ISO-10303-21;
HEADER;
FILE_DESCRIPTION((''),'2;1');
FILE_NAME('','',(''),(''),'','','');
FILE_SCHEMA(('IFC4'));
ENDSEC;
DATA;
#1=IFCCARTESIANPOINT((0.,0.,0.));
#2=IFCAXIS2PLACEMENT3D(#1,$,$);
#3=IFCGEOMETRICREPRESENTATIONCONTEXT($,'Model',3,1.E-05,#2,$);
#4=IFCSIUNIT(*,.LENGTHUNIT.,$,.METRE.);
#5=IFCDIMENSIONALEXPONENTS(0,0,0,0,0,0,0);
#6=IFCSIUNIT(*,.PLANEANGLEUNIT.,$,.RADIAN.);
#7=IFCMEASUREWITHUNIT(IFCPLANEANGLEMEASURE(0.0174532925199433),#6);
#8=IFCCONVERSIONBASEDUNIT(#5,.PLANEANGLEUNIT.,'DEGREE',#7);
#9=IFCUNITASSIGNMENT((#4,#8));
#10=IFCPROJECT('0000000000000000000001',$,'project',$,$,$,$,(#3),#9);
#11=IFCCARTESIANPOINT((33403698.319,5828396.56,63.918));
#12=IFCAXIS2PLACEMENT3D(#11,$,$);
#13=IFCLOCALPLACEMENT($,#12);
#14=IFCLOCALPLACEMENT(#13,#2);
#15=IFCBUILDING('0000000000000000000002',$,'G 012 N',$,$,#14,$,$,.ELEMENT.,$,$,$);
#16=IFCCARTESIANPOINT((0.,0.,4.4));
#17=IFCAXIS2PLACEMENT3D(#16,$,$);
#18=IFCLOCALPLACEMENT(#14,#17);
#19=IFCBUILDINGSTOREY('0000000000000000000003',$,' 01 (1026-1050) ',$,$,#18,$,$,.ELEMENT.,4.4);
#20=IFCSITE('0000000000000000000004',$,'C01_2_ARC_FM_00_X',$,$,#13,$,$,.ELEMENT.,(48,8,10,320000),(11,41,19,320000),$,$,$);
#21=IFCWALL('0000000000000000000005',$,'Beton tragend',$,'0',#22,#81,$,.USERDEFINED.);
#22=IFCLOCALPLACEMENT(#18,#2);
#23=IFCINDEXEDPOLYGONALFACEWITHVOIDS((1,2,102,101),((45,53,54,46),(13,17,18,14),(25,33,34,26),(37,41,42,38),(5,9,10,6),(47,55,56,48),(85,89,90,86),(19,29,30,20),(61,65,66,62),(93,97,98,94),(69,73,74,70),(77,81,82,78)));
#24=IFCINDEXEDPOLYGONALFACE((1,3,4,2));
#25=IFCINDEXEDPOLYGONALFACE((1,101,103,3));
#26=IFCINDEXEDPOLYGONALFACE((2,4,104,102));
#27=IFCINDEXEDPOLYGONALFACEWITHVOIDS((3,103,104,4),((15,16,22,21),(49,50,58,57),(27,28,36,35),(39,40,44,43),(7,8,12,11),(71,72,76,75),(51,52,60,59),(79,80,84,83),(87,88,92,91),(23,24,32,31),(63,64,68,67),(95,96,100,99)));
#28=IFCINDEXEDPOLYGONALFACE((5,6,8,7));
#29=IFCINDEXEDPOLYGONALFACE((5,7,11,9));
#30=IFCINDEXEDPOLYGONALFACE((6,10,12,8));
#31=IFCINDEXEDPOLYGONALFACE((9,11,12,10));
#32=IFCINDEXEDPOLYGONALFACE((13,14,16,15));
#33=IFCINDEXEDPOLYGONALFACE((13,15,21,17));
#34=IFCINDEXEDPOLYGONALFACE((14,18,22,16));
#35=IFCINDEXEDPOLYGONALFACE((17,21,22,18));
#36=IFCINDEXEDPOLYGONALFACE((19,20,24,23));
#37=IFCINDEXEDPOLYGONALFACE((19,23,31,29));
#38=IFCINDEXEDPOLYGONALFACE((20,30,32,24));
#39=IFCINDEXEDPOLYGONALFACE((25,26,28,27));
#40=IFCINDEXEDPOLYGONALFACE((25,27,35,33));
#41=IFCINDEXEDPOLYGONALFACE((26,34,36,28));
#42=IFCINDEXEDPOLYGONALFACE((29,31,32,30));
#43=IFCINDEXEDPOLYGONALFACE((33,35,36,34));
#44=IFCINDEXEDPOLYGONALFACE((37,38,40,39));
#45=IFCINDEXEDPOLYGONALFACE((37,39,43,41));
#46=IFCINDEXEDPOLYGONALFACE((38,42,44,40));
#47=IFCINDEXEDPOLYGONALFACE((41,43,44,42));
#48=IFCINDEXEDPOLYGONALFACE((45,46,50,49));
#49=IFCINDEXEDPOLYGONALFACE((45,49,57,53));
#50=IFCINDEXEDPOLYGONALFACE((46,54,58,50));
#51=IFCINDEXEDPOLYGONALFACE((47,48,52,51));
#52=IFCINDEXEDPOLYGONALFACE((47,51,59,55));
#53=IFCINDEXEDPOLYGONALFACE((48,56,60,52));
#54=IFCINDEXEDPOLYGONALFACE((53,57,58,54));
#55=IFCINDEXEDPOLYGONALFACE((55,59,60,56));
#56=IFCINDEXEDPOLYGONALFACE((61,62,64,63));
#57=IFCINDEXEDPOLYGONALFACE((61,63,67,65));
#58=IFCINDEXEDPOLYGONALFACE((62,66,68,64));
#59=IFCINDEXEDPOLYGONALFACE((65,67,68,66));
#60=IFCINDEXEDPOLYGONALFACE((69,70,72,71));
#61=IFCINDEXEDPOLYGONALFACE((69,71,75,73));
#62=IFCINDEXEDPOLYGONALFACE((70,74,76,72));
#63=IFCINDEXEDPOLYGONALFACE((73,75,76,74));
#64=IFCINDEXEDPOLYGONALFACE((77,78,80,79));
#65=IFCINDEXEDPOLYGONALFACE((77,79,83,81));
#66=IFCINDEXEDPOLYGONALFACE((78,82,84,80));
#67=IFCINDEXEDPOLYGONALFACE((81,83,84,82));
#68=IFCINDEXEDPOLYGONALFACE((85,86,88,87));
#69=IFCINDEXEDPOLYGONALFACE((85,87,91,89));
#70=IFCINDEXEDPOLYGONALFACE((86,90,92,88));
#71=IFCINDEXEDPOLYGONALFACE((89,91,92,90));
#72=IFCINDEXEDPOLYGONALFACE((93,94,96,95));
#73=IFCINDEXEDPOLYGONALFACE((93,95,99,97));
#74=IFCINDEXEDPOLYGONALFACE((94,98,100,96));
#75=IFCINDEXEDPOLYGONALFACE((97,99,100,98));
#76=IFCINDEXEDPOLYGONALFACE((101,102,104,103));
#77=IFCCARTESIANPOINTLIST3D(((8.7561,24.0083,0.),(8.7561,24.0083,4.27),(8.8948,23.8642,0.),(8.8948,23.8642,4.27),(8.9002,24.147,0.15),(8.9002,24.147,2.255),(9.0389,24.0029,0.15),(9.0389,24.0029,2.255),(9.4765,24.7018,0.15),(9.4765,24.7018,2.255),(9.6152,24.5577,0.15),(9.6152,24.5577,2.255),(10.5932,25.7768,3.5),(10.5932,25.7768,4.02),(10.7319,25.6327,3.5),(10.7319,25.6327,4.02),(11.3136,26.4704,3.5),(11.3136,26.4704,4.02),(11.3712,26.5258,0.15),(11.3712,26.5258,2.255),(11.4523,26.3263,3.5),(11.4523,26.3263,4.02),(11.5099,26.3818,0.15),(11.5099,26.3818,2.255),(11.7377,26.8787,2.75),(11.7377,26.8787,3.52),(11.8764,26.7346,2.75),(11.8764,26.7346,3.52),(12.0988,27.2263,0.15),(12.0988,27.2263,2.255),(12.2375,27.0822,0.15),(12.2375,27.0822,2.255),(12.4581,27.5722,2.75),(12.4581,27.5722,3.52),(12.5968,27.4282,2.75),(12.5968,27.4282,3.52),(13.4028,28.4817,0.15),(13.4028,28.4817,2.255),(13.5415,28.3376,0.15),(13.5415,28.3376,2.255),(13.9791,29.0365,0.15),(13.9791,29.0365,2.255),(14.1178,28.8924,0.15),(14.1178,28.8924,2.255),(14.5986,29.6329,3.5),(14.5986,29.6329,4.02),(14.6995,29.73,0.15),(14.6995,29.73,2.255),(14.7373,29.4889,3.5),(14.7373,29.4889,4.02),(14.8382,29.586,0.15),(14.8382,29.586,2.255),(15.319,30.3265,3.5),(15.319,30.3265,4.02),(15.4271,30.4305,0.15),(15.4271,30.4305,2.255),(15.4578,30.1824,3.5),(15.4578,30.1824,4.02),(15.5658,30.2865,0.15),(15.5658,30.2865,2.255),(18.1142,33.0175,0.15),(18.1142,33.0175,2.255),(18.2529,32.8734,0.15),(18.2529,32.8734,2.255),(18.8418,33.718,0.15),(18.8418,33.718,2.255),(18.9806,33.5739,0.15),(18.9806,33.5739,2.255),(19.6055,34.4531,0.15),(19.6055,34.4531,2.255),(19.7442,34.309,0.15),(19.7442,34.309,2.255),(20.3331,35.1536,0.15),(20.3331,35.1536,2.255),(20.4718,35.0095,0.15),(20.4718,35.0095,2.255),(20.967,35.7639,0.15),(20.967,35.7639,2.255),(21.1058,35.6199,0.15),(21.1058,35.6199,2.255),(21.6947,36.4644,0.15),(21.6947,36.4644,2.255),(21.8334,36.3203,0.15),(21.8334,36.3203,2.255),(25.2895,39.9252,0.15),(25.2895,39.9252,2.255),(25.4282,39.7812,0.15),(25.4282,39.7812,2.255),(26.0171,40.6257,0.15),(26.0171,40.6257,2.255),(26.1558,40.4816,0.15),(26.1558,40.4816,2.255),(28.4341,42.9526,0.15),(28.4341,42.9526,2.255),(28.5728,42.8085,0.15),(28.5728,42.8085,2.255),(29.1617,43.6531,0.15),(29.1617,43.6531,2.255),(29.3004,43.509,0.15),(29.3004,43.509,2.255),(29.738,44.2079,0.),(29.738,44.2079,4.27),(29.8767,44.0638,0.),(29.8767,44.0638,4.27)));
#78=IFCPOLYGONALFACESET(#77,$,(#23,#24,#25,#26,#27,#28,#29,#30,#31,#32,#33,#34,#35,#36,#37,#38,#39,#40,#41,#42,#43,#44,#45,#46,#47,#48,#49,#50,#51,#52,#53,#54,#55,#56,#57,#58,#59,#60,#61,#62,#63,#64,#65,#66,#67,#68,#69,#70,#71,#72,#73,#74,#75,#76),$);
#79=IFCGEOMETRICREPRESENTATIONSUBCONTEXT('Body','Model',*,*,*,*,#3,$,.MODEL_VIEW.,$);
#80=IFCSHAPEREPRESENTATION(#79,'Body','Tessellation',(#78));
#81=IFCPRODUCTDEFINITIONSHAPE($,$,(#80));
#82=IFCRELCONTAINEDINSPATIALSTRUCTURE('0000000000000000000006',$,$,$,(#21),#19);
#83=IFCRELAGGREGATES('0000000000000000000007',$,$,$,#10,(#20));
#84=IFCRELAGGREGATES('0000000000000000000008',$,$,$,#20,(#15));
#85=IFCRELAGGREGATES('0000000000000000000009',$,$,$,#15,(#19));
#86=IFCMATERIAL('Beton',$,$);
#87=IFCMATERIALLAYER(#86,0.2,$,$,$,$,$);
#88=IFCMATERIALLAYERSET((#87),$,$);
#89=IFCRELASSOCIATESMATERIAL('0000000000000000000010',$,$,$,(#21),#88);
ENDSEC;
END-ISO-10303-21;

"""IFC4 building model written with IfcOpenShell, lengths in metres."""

from ifc_helpers import new_model, entity, si_unit, converted_unit, frame, frame_2d, origin, origin_with_axes, place, context, subcontext, project, spatial, polyline, rectangle, outline, extrude, material, layer, layer_set, layer_usage, element, save


model = new_model("IFC4")

# Units and contexts
model_context = context("Model", 3, precision=1e-05, world=origin())
body_context = subcontext(model_context, "Body", "Model", "MODEL_VIEW")
ifc_project = project(units=[si_unit("LENGTHUNIT", "METRE"), converted_unit("PLANEANGLEUNIT", "DEGREE", entity("IfcPlaneAngleMeasure", 0.0174532925199433), si_unit("PLANEANGLEUNIT", "RADIAN"), dimensions=[0, 0, 0, 0, 0, 0, 0])], contexts=[model_context])

# Site, building, storey
site_placement = place(None, frame((33403698.319, 5828396.56, 63.918)))
site = spatial("IfcSite", under=ifc_project, at=site_placement, Name="C01_2_ARC_FM_00_X", CompositionType="ELEMENT", RefLatitude=(48, 8, 10, 320000), RefLongitude=(11, 41, 19, 320000))
building_placement = place(site_placement, origin())
building = spatial("IfcBuilding", under=site, at=building_placement, Name="G 012 N", CompositionType="ELEMENT")
storey_placement = place(building_placement, frame((0.0, 0.0, 4.4)))
storey = spatial("IfcBuildingStorey", under=building, at=storey_placement, Name=" 01 (1026-1050) ", CompositionType="ELEMENT", Elevation=4.4)

# Wall, openings
ifc_material_1 = material(Name="Beton")
ifc_layer_1 = layer(ifc_material_1, 0.2)
ifc_layer_set_1 = layer_set([ifc_layer_1])
ifc_layer_usage_1 = layer_usage(ifc_layer_set_1, "AXIS2", "POSITIVE", 0.0)
wall_1_placement = place(storey_placement, frame((29.738, 44.2079, 0.0), z_axis=(0.0, 0.0, 1.0), x_axis=(-0.720408, -0.693551, 0.0)))
wall_1 = element("IfcWall", 1, at=wall_1_placement, inside=storey, material=ifc_layer_usage_1, Name="Beton tragend", ObjectType="0", PredefinedType="USERDEFINED", context=body_context, shape_type="SweptSolid", body=[
    extrude(rectangle(XDim=29.125, YDim=0.2, at=frame_2d((14.5625, 0.1), x_axis=(1.0, 0.0))), origin_with_axes(), (0.0, 0.0, 1.0), 4.27),
])
opening_1_placement = place(wall_1_placement, frame((26.575, 0.2, 3.5), z_axis=(0.0, -1.0, 0.0), x_axis=(0.0, 0.0, 1.0)))
element("IfcOpeningElement", 2, at=opening_1_placement, cuts=wall_1, ObjectType="0", PredefinedType="USERDEFINED", context=body_context, shape_type="SweptSolid", body=[
    extrude(outline(polyline([(0.0, 1.0), (0.52, 1.0), (0.52, 0.0), (0.0, 0.0), (0.0, 1.0)])), origin_with_axes(), (0.0, 0.0, 1.0), 0.2),
])
opening_2_placement = place(wall_1_placement, frame((24.9862, 0.2, 2.75), z_axis=(0.0, -1.0, 0.0), x_axis=(0.0, 0.0, 1.0)))
element("IfcOpeningElement", 3, at=opening_2_placement, cuts=wall_1, ObjectType="0", PredefinedType="USERDEFINED", context=body_context, shape_type="SweptSolid", body=[
    extrude(outline(polyline([(0.0, 1.0), (0.77, 1.0), (0.77, 0.0), (0.0, 0.0), (0.0, 1.0)])), origin_with_axes(), (0.0, 0.0, 1.0), 0.2),
])
opening_3_placement = place(wall_1_placement, frame((28.125, 0.0, 0.15), z_axis=(0.0, 1.0, 0.0), x_axis=(0.0, 0.0, 1.0)))
element("IfcOpeningElement", 4, at=opening_3_placement, cuts=wall_1, ObjectType="Opening", context=body_context, shape_type="SweptSolid", body=[
    extrude(outline(polyline([(0.0, 0.8), (2.105, 0.8), (2.105, 0.0), (0.0, 0.0), (0.0, 0.8)])), origin_with_axes(), (0.0, 0.0, 1.0), 0.2),
])
opening_4_placement = place(wall_1_placement, frame((0.8, 0.0, 0.15), z_axis=(0.0, 1.0, 0.0), x_axis=(0.0, 0.0, 1.0)))
element("IfcOpeningElement", 5, at=opening_4_placement, cuts=wall_1, ObjectType="Opening", context=body_context, shape_type="SweptSolid", body=[
    extrude(outline(polyline([(0.0, 1.01), (2.105, 1.01), (2.105, 0.0), (0.0, 0.0), (0.0, 1.01)])), origin_with_axes(), (0.0, 0.0, 1.0), 0.2),
])
opening_5_placement = place(wall_1_placement, frame((13.055, 0.0, 0.15), z_axis=(0.0, 1.0, 0.0), x_axis=(0.0, 0.0, 1.0)))
element("IfcOpeningElement", 6, at=opening_5_placement, cuts=wall_1, ObjectType="Opening", context=body_context, shape_type="SweptSolid", body=[
    extrude(outline(polyline([(0.0, 1.01), (2.105, 1.01), (2.105, 0.0), (0.0, 0.0), (0.0, 1.01)])), origin_with_axes(), (0.0, 0.0, 1.0), 0.2),
])
opening_6_placement = place(wall_1_placement, frame((24.485, 0.0, 0.15), z_axis=(0.0, 1.0, 0.0), x_axis=(0.0, 0.0, 1.0)))
element("IfcOpeningElement", 7, at=opening_6_placement, cuts=wall_1, ObjectType="Opening", context=body_context, shape_type="SweptSolid", body=[
    extrude(outline(polyline([(0.0, 1.01), (2.105, 1.01), (2.105, 0.0), (0.0, 0.0), (0.0, 1.01)])), origin_with_axes(), (0.0, 0.0, 1.0), 0.2),
])
opening_7_placement = place(wall_1_placement, frame((21.875, 0.0, 0.15), z_axis=(0.0, 1.0, 0.0), x_axis=(0.0, 0.0, 1.0)))
element("IfcOpeningElement", 8, at=opening_7_placement, cuts=wall_1, ObjectType="Opening", context=body_context, shape_type="SweptSolid", body=[
    extrude(outline(polyline([(0.0, 0.8), (2.105, 0.8), (2.105, 0.0), (0.0, 0.0), (0.0, 0.8)])), origin_with_axes(), (0.0, 0.0, 1.0), 0.2),
])
opening_8_placement = place(wall_1_placement, frame((19.865, 0.0, 0.15), z_axis=(0.0, 1.0, 0.0), x_axis=(0.0, 0.0, 1.0)))
element("IfcOpeningElement", 9, at=opening_8_placement, cuts=wall_1, ObjectType="Opening", context=body_context, shape_type="SweptSolid", body=[
    extrude(outline(polyline([(0.0, 1.01), (2.105, 1.01), (2.105, 0.0), (0.0, 0.0), (0.0, 1.01)])), origin_with_axes(), (0.0, 0.0, 1.0), 0.2),
])
opening_9_placement = place(wall_1_placement, frame((21.015, 0.2, 3.5), z_axis=(0.0, -1.0, 0.0), x_axis=(0.0, 0.0, 1.0)))
element("IfcOpeningElement", 10, at=opening_9_placement, cuts=wall_1, ObjectType="0", PredefinedType="USERDEFINED", context=body_context, shape_type="SweptSolid", body=[
    extrude(outline(polyline([(0.0, 1.0), (0.52, 1.0), (0.52, 0.0), (0.0, 0.0), (0.0, 1.0)])), origin_with_axes(), (0.0, 0.0, 1.0), 0.2),
])
opening_10_placement = place(wall_1_placement, frame((16.135, 0.2, 0.15), z_axis=(0.0, -1.0, 0.0), x_axis=(0.0, 0.0, 1.0)))
element("IfcOpeningElement", 11, at=opening_10_placement, cuts=wall_1, ObjectType="Opening", context=body_context, shape_type="SweptSolid", body=[
    extrude(outline(polyline([(0.0, 1.01), (2.105, 1.01), (2.105, 0.0), (0.0, 0.0), (0.0, 1.01)])), origin_with_axes(), (0.0, 0.0, 1.0), 0.2),
])
opening_11_placement = place(wall_1_placement, frame((11.165, 0.0, 0.15), z_axis=(0.0, 1.0, 0.0), x_axis=(0.0, 0.0, 1.0)))
element("IfcOpeningElement", 12, at=opening_11_placement, cuts=wall_1, ObjectType="Opening", context=body_context, shape_type="SweptSolid", body=[
    extrude(outline(polyline([(0.0, 1.01), (2.105, 1.01), (2.105, 0.0), (0.0, 0.0), (0.0, 1.01)])), origin_with_axes(), (0.0, 0.0, 1.0), 0.2),
])
opening_12_placement = place(wall_1_placement, frame((6.175, 0.2, 0.15), z_axis=(0.0, -1.0, 0.0), x_axis=(0.0, 0.0, 1.0)))
element("IfcOpeningElement", 13, at=opening_12_placement, cuts=wall_1, ObjectType="Opening", context=body_context, shape_type="SweptSolid", body=[
    extrude(outline(polyline([(0.0, 1.01), (2.105, 1.01), (2.105, 0.0), (0.0, 0.0), (0.0, 1.01)])), origin_with_axes(), (0.0, 0.0, 1.0), 0.2),
])

save(model, "model.ifc")
